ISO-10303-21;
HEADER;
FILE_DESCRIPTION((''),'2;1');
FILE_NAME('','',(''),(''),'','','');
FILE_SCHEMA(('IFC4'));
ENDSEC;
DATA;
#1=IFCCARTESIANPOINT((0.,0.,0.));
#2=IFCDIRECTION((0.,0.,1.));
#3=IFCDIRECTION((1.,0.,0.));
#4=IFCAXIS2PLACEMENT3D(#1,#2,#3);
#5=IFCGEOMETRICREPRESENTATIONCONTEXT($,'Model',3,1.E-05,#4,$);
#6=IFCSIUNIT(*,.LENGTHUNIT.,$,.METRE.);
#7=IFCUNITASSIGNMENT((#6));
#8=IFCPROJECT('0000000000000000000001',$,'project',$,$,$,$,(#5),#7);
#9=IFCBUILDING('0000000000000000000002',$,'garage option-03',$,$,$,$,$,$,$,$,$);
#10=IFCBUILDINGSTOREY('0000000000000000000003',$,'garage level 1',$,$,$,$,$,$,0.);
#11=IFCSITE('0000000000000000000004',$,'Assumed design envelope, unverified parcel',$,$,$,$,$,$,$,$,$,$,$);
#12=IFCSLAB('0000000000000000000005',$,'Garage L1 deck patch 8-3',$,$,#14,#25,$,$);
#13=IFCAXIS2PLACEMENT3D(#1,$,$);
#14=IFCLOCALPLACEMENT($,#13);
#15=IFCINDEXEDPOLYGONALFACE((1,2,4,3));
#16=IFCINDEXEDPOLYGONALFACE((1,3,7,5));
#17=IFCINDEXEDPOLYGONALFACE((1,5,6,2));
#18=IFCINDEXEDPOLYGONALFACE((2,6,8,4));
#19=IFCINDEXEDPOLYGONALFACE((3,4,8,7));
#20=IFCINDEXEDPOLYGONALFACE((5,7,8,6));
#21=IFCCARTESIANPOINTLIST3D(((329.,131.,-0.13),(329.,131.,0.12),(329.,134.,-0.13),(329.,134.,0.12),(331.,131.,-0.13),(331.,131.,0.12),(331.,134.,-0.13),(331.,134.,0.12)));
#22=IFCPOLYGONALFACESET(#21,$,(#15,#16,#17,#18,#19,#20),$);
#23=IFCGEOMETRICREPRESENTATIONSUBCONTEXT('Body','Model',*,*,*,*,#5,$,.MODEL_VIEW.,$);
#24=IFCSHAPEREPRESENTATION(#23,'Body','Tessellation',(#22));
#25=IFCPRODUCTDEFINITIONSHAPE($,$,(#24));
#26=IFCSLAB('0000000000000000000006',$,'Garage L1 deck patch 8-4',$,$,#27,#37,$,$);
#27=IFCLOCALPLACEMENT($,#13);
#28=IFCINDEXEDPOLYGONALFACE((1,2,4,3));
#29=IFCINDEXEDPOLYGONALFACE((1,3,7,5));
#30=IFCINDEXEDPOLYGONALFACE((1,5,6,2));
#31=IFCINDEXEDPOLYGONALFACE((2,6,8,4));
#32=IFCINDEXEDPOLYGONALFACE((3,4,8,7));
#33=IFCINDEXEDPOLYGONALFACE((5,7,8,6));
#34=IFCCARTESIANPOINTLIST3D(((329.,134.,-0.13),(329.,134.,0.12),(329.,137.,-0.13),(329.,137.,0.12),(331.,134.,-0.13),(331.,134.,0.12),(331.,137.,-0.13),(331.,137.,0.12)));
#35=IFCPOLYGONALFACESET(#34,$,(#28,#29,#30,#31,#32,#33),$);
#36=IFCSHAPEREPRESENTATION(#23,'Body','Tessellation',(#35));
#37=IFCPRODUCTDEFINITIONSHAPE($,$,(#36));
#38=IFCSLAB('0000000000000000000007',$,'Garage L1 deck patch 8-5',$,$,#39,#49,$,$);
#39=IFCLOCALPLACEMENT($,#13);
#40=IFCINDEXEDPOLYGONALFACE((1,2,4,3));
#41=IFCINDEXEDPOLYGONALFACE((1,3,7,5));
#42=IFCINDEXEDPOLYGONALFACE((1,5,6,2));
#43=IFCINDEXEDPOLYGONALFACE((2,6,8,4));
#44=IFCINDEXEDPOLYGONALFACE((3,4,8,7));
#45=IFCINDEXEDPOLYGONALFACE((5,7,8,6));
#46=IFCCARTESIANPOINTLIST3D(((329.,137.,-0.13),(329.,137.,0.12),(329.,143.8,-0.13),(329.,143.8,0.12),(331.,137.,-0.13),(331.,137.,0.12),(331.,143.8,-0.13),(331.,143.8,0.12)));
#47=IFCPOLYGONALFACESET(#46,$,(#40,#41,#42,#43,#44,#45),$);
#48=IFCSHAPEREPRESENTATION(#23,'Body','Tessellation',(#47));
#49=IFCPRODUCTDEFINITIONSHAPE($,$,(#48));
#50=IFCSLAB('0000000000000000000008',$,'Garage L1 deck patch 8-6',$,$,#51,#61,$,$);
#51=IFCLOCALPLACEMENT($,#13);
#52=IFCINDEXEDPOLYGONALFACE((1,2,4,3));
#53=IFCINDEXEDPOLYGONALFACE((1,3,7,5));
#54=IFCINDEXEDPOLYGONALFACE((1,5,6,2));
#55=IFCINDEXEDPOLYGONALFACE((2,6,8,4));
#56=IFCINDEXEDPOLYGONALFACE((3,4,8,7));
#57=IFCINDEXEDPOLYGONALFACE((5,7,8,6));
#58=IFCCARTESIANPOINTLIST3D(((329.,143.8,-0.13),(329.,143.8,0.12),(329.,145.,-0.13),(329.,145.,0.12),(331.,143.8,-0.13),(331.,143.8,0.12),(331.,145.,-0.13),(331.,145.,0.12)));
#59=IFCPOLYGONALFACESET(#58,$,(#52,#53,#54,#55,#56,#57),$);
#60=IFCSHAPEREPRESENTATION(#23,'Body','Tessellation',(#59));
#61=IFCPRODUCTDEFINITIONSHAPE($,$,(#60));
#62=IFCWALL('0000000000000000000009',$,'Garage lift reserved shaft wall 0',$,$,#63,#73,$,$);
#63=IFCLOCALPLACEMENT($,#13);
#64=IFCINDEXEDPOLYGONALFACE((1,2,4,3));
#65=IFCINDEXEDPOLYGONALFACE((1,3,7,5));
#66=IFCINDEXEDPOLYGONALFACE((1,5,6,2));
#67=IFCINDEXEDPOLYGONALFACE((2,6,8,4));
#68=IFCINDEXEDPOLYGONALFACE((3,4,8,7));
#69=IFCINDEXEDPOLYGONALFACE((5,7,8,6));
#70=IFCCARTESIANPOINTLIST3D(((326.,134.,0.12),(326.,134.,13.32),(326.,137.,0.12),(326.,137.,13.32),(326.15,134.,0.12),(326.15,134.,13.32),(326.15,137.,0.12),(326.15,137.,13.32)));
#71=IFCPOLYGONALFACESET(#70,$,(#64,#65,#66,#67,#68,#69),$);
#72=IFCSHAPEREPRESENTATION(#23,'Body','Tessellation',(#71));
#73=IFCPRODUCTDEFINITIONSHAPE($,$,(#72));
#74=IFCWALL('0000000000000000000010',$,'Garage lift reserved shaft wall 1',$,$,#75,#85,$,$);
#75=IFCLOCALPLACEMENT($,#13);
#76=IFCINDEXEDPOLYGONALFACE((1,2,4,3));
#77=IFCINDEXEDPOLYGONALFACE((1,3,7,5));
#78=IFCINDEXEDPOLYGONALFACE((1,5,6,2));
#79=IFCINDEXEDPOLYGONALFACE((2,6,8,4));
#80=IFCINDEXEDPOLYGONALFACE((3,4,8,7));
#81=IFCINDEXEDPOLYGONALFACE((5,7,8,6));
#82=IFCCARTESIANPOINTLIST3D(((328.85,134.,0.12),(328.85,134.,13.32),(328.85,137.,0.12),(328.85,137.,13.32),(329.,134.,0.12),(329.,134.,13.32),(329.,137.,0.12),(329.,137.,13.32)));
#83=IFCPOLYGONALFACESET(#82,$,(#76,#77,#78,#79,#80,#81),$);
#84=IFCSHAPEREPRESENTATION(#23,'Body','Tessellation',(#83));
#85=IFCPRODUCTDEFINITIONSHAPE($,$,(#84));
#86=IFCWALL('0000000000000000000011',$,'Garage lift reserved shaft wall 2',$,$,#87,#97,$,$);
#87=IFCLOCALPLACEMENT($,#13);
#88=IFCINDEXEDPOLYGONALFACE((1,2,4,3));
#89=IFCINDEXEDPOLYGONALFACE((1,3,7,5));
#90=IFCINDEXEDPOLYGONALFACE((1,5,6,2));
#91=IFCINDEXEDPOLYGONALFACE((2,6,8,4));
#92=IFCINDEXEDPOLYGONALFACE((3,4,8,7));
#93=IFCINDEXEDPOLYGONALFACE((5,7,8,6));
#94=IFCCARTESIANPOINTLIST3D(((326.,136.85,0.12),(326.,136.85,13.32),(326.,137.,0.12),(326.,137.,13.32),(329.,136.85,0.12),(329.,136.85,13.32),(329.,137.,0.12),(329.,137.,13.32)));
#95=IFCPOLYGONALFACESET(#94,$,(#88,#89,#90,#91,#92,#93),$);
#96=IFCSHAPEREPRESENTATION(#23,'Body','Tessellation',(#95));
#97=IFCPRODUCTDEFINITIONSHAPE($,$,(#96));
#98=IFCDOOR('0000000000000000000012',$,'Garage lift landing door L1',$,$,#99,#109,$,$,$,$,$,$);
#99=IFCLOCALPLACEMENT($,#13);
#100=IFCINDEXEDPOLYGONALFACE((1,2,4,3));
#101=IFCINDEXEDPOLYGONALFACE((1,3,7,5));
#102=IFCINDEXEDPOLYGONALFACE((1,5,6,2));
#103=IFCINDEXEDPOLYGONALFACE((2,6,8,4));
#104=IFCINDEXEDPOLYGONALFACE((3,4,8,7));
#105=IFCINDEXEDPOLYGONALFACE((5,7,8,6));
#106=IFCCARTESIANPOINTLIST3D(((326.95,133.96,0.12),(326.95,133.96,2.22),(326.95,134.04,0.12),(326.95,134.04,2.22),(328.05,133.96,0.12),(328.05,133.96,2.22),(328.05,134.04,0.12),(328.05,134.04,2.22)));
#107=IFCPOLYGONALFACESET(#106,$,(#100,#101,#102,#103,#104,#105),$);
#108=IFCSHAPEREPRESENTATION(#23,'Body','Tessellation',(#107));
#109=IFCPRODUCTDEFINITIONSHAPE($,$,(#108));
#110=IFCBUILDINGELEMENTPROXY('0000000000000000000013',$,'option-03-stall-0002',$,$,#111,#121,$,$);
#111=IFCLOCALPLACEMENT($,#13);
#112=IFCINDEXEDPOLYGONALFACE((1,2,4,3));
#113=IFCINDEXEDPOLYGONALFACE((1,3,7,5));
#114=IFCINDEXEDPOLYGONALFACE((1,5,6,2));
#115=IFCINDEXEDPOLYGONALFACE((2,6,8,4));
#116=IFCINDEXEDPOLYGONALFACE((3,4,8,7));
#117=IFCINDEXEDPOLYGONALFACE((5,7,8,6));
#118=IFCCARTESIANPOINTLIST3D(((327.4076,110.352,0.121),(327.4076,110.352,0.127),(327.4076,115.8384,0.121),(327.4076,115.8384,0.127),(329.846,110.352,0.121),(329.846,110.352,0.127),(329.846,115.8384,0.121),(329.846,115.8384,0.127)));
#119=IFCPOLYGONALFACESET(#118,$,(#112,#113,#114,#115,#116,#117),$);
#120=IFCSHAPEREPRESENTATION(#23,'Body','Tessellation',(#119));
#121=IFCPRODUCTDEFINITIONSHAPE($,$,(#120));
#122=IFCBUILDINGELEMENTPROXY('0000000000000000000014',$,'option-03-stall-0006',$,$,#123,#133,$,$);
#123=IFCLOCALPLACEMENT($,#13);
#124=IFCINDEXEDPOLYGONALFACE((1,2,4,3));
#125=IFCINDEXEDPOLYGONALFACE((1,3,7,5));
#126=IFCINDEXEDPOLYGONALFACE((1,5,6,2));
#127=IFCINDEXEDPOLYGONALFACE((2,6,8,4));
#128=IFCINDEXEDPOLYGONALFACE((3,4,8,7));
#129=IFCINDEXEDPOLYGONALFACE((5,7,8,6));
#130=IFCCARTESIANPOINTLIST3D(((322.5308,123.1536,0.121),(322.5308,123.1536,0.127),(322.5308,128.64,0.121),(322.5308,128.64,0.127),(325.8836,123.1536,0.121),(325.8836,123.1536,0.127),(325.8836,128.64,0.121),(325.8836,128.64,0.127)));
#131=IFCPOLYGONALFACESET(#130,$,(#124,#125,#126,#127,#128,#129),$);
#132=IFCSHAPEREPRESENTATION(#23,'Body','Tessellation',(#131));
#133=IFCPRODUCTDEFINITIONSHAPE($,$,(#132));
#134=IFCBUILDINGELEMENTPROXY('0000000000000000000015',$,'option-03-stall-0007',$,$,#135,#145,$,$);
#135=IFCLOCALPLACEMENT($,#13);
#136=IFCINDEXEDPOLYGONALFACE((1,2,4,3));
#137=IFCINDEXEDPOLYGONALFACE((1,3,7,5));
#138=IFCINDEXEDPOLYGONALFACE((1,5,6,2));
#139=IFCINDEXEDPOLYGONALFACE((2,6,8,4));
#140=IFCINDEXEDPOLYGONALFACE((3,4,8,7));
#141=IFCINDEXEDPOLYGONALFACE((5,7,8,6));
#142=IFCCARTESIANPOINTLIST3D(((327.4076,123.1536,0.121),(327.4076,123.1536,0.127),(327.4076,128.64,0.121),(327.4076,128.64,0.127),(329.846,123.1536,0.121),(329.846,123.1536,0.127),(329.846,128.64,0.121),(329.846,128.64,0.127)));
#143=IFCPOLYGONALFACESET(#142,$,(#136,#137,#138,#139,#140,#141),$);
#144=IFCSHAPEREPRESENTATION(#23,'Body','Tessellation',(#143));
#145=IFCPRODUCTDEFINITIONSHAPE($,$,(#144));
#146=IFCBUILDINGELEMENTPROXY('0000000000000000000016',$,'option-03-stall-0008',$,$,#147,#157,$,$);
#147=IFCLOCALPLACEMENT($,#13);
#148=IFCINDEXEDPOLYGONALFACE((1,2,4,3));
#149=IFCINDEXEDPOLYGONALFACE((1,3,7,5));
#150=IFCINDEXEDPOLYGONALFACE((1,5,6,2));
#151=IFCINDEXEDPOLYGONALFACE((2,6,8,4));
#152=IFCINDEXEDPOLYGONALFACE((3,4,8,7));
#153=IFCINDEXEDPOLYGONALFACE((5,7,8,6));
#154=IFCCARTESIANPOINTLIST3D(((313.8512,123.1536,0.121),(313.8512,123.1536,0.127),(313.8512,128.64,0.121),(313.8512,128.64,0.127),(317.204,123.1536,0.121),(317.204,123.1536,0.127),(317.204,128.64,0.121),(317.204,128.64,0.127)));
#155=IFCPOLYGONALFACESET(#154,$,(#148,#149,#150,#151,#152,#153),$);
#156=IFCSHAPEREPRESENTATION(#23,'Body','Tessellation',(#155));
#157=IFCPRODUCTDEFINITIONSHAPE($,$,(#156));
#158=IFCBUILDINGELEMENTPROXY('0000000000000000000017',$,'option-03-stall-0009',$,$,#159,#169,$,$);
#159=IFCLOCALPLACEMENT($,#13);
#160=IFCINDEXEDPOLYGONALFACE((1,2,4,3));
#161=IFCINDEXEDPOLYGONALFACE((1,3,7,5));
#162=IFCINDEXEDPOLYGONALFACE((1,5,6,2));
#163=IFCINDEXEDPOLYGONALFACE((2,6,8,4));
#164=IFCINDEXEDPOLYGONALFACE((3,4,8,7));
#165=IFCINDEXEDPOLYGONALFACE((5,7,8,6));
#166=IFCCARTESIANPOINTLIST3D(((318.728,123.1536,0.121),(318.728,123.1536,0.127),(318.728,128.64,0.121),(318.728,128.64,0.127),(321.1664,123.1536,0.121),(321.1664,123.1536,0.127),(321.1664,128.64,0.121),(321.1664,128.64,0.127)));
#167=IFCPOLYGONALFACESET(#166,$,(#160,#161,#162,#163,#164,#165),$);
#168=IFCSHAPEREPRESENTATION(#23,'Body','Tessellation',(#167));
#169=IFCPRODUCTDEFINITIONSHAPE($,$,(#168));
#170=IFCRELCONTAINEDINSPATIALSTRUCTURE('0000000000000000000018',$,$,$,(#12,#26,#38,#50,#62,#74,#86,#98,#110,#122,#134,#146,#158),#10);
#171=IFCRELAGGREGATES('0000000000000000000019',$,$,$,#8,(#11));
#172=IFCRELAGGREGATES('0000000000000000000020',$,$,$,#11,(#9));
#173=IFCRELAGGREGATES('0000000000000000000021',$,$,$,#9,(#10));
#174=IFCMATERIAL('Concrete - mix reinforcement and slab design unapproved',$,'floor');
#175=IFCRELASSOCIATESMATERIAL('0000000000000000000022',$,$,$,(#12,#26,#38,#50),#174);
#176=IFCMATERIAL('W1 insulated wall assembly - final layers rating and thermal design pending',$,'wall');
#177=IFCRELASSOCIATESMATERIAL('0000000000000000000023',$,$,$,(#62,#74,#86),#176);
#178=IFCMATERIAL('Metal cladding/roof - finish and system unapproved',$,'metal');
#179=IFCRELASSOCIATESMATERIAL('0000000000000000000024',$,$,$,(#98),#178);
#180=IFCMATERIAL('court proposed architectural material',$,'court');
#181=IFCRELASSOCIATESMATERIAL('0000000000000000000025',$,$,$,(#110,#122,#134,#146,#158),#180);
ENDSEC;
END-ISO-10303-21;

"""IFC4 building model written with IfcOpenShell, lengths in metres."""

from ifc_helpers import new_model, si_unit, frame, origin_with_axes, place, context, subcontext, project, spatial, rectangle, extrude, material, element, save


model = new_model("IFC4")

# Units and contexts
model_context = context("Model", 3, precision=1e-05, world=origin_with_axes())
body_context = subcontext(model_context, "Body", "Model", "MODEL_VIEW")
ifc_project = project(units=[si_unit("LENGTHUNIT", "METRE")], contexts=[model_context])

# Site, building, storey
site = spatial("IfcSite", under=ifc_project, Name="Assumed design envelope, unverified parcel")
building = spatial("IfcBuilding", under=site, Name="garage option-03")
storey = spatial("IfcBuildingStorey", under=building, Name="garage level 1", Elevation=0.0)

# Shared definitions
ifc_material_1 = material(Name="Concrete - mix reinforcement and slab design unapproved", Category="floor")

# Slabs
for number, where, z_axis, x_axis, name in (
    (1, (330.0, 132.5, -0.13), (0.0, 0.0, 1.0), (1.0, 0.0, 0.0), "Garage L1 deck patch 8-3"),
    (2, (330.0, 135.5, -0.13), (0.0, 0.0, 1.0), (1.0, 0.0, 0.0), "Garage L1 deck patch 8-4"),
):
    element("IfcSlab", number, at=place(None, frame(where, z_axis=z_axis, x_axis=x_axis)), inside=storey, material=ifc_material_1, Name=name, context=body_context, shape_type="SweptSolid", body=[
        extrude(rectangle(XDim=2.0, YDim=3.0), origin_with_axes(), (0.0, 0.0, 1.0), 0.25),
    ])
slab_1_placement = place(None, frame((330.0, 140.4, -0.13), z_axis=(0.0, 0.0, 1.0), x_axis=(1.0, 0.0, 0.0)))
element("IfcSlab", 3, at=slab_1_placement, inside=storey, material=ifc_material_1, Name="Garage L1 deck patch 8-5", context=body_context, shape_type="SweptSolid", body=[
    extrude(rectangle(XDim=2.0, YDim=6.8), origin_with_axes(), (0.0, 0.0, 1.0), 0.25),
])
slab_2_placement = place(None, frame((330.0, 144.4, -0.13), z_axis=(0.0, 0.0, 1.0), x_axis=(1.0, 0.0, 0.0)))
element("IfcSlab", 4, at=slab_2_placement, inside=storey, material=ifc_material_1, Name="Garage L1 deck patch 8-6", context=body_context, shape_type="SweptSolid", body=[
    extrude(rectangle(XDim=2.0, YDim=1.2), origin_with_axes(), (0.0, 0.0, 1.0), 0.25),
])

# Walls
ifc_material_2 = material(Name="W1 insulated wall assembly - final layers rating and thermal design pending", Category="wall")
for number, where, z_axis, x_axis, name in (
    (5, (326.075, 135.5, 0.12), (0.0, 0.0, 1.0), (1.0, 0.0, 0.0), "Garage lift reserved shaft wall 0"),
    (6, (328.925, 135.5, 0.12), (0.0, 0.0, 1.0), (1.0, 0.0, 0.0), "Garage lift reserved shaft wall 1"),
):
    element("IfcWall", number, at=place(None, frame(where, z_axis=z_axis, x_axis=x_axis)), inside=storey, material=ifc_material_2, Name=name, context=body_context, shape_type="SweptSolid", body=[
        extrude(rectangle(XDim=0.15, YDim=3.0), origin_with_axes(), (0.0, 0.0, 1.0), 13.2),
    ])
wall_placement = place(None, frame((327.5, 136.925, 0.12), z_axis=(0.0, 0.0, 1.0), x_axis=(1.0, 0.0, 0.0)))
element("IfcWall", 7, at=wall_placement, inside=storey, material=ifc_material_2, Name="Garage lift reserved shaft wall 2", context=body_context, shape_type="SweptSolid", body=[
    extrude(rectangle(XDim=3.0, YDim=0.15), origin_with_axes(), (0.0, 0.0, 1.0), 13.2),
])

# Door
ifc_material_3 = material(Name="Metal cladding/roof - finish and system unapproved", Category="metal")
door_placement = place(None, frame((327.5, 134.0, 0.12), z_axis=(0.0, 0.0, 1.0), x_axis=(1.0, 0.0, 0.0)))
element("IfcDoor", 8, at=door_placement, inside=storey, material=ifc_material_3, Name="Garage lift landing door L1", context=body_context, shape_type="SweptSolid", body=[
    extrude(rectangle(XDim=1.1, YDim=0.08), origin_with_axes(), (0.0, 0.0, 1.0), 2.1),
])

# Building element proxies
ifc_material_4 = material(Name="court proposed architectural material", Category="court")
proxy_1_placement = place(None, frame((328.6268, 113.0952, 0.121), z_axis=(0.0, 0.0, 1.0), x_axis=(1.0, 0.0, 0.0)))
element("IfcBuildingElementProxy", 9, at=proxy_1_placement, inside=storey, material=ifc_material_4, Name="option-03-stall-0002", context=body_context, shape_type="SweptSolid", body=[
    extrude(rectangle(XDim=2.4384, YDim=5.4864), origin_with_axes(), (0.0, 0.0, 1.0), 0.006),
])
proxy_2_placement = place(None, frame((324.2072, 125.8968, 0.121), z_axis=(0.0, 0.0, 1.0), x_axis=(1.0, 0.0, 0.0)))
element("IfcBuildingElementProxy", 10, at=proxy_2_placement, inside=storey, material=ifc_material_4, Name="option-03-stall-0006", context=body_context, shape_type="SweptSolid", body=[
    extrude(rectangle(XDim=3.3528, YDim=5.4864), origin_with_axes(), (0.0, 0.0, 1.0), 0.006),
])
proxy_3_placement = place(None, frame((328.6268, 125.8968, 0.121), z_axis=(0.0, 0.0, 1.0), x_axis=(1.0, 0.0, 0.0)))
element("IfcBuildingElementProxy", 11, at=proxy_3_placement, inside=storey, material=ifc_material_4, Name="option-03-stall-0007", context=body_context, shape_type="SweptSolid", body=[
    extrude(rectangle(XDim=2.4384, YDim=5.4864), origin_with_axes(), (0.0, 0.0, 1.0), 0.006),
])
proxy_4_placement = place(None, frame((315.5276, 125.8968, 0.121), z_axis=(0.0, 0.0, 1.0), x_axis=(1.0, 0.0, 0.0)))
element("IfcBuildingElementProxy", 12, at=proxy_4_placement, inside=storey, material=ifc_material_4, Name="option-03-stall-0008", context=body_context, shape_type="SweptSolid", body=[
    extrude(rectangle(XDim=3.3528, YDim=5.4864), origin_with_axes(), (0.0, 0.0, 1.0), 0.006),
])
proxy_5_placement = place(None, frame((319.9472, 125.8968, 0.121), z_axis=(0.0, 0.0, 1.0), x_axis=(1.0, 0.0, 0.0)))
element("IfcBuildingElementProxy", 13, at=proxy_5_placement, inside=storey, material=ifc_material_4, Name="option-03-stall-0009", context=body_context, shape_type="SweptSolid", body=[
    extrude(rectangle(XDim=2.4384, YDim=5.4864), origin_with_axes(), (0.0, 0.0, 1.0), 0.006),
])

save(model, "model.ifc")
